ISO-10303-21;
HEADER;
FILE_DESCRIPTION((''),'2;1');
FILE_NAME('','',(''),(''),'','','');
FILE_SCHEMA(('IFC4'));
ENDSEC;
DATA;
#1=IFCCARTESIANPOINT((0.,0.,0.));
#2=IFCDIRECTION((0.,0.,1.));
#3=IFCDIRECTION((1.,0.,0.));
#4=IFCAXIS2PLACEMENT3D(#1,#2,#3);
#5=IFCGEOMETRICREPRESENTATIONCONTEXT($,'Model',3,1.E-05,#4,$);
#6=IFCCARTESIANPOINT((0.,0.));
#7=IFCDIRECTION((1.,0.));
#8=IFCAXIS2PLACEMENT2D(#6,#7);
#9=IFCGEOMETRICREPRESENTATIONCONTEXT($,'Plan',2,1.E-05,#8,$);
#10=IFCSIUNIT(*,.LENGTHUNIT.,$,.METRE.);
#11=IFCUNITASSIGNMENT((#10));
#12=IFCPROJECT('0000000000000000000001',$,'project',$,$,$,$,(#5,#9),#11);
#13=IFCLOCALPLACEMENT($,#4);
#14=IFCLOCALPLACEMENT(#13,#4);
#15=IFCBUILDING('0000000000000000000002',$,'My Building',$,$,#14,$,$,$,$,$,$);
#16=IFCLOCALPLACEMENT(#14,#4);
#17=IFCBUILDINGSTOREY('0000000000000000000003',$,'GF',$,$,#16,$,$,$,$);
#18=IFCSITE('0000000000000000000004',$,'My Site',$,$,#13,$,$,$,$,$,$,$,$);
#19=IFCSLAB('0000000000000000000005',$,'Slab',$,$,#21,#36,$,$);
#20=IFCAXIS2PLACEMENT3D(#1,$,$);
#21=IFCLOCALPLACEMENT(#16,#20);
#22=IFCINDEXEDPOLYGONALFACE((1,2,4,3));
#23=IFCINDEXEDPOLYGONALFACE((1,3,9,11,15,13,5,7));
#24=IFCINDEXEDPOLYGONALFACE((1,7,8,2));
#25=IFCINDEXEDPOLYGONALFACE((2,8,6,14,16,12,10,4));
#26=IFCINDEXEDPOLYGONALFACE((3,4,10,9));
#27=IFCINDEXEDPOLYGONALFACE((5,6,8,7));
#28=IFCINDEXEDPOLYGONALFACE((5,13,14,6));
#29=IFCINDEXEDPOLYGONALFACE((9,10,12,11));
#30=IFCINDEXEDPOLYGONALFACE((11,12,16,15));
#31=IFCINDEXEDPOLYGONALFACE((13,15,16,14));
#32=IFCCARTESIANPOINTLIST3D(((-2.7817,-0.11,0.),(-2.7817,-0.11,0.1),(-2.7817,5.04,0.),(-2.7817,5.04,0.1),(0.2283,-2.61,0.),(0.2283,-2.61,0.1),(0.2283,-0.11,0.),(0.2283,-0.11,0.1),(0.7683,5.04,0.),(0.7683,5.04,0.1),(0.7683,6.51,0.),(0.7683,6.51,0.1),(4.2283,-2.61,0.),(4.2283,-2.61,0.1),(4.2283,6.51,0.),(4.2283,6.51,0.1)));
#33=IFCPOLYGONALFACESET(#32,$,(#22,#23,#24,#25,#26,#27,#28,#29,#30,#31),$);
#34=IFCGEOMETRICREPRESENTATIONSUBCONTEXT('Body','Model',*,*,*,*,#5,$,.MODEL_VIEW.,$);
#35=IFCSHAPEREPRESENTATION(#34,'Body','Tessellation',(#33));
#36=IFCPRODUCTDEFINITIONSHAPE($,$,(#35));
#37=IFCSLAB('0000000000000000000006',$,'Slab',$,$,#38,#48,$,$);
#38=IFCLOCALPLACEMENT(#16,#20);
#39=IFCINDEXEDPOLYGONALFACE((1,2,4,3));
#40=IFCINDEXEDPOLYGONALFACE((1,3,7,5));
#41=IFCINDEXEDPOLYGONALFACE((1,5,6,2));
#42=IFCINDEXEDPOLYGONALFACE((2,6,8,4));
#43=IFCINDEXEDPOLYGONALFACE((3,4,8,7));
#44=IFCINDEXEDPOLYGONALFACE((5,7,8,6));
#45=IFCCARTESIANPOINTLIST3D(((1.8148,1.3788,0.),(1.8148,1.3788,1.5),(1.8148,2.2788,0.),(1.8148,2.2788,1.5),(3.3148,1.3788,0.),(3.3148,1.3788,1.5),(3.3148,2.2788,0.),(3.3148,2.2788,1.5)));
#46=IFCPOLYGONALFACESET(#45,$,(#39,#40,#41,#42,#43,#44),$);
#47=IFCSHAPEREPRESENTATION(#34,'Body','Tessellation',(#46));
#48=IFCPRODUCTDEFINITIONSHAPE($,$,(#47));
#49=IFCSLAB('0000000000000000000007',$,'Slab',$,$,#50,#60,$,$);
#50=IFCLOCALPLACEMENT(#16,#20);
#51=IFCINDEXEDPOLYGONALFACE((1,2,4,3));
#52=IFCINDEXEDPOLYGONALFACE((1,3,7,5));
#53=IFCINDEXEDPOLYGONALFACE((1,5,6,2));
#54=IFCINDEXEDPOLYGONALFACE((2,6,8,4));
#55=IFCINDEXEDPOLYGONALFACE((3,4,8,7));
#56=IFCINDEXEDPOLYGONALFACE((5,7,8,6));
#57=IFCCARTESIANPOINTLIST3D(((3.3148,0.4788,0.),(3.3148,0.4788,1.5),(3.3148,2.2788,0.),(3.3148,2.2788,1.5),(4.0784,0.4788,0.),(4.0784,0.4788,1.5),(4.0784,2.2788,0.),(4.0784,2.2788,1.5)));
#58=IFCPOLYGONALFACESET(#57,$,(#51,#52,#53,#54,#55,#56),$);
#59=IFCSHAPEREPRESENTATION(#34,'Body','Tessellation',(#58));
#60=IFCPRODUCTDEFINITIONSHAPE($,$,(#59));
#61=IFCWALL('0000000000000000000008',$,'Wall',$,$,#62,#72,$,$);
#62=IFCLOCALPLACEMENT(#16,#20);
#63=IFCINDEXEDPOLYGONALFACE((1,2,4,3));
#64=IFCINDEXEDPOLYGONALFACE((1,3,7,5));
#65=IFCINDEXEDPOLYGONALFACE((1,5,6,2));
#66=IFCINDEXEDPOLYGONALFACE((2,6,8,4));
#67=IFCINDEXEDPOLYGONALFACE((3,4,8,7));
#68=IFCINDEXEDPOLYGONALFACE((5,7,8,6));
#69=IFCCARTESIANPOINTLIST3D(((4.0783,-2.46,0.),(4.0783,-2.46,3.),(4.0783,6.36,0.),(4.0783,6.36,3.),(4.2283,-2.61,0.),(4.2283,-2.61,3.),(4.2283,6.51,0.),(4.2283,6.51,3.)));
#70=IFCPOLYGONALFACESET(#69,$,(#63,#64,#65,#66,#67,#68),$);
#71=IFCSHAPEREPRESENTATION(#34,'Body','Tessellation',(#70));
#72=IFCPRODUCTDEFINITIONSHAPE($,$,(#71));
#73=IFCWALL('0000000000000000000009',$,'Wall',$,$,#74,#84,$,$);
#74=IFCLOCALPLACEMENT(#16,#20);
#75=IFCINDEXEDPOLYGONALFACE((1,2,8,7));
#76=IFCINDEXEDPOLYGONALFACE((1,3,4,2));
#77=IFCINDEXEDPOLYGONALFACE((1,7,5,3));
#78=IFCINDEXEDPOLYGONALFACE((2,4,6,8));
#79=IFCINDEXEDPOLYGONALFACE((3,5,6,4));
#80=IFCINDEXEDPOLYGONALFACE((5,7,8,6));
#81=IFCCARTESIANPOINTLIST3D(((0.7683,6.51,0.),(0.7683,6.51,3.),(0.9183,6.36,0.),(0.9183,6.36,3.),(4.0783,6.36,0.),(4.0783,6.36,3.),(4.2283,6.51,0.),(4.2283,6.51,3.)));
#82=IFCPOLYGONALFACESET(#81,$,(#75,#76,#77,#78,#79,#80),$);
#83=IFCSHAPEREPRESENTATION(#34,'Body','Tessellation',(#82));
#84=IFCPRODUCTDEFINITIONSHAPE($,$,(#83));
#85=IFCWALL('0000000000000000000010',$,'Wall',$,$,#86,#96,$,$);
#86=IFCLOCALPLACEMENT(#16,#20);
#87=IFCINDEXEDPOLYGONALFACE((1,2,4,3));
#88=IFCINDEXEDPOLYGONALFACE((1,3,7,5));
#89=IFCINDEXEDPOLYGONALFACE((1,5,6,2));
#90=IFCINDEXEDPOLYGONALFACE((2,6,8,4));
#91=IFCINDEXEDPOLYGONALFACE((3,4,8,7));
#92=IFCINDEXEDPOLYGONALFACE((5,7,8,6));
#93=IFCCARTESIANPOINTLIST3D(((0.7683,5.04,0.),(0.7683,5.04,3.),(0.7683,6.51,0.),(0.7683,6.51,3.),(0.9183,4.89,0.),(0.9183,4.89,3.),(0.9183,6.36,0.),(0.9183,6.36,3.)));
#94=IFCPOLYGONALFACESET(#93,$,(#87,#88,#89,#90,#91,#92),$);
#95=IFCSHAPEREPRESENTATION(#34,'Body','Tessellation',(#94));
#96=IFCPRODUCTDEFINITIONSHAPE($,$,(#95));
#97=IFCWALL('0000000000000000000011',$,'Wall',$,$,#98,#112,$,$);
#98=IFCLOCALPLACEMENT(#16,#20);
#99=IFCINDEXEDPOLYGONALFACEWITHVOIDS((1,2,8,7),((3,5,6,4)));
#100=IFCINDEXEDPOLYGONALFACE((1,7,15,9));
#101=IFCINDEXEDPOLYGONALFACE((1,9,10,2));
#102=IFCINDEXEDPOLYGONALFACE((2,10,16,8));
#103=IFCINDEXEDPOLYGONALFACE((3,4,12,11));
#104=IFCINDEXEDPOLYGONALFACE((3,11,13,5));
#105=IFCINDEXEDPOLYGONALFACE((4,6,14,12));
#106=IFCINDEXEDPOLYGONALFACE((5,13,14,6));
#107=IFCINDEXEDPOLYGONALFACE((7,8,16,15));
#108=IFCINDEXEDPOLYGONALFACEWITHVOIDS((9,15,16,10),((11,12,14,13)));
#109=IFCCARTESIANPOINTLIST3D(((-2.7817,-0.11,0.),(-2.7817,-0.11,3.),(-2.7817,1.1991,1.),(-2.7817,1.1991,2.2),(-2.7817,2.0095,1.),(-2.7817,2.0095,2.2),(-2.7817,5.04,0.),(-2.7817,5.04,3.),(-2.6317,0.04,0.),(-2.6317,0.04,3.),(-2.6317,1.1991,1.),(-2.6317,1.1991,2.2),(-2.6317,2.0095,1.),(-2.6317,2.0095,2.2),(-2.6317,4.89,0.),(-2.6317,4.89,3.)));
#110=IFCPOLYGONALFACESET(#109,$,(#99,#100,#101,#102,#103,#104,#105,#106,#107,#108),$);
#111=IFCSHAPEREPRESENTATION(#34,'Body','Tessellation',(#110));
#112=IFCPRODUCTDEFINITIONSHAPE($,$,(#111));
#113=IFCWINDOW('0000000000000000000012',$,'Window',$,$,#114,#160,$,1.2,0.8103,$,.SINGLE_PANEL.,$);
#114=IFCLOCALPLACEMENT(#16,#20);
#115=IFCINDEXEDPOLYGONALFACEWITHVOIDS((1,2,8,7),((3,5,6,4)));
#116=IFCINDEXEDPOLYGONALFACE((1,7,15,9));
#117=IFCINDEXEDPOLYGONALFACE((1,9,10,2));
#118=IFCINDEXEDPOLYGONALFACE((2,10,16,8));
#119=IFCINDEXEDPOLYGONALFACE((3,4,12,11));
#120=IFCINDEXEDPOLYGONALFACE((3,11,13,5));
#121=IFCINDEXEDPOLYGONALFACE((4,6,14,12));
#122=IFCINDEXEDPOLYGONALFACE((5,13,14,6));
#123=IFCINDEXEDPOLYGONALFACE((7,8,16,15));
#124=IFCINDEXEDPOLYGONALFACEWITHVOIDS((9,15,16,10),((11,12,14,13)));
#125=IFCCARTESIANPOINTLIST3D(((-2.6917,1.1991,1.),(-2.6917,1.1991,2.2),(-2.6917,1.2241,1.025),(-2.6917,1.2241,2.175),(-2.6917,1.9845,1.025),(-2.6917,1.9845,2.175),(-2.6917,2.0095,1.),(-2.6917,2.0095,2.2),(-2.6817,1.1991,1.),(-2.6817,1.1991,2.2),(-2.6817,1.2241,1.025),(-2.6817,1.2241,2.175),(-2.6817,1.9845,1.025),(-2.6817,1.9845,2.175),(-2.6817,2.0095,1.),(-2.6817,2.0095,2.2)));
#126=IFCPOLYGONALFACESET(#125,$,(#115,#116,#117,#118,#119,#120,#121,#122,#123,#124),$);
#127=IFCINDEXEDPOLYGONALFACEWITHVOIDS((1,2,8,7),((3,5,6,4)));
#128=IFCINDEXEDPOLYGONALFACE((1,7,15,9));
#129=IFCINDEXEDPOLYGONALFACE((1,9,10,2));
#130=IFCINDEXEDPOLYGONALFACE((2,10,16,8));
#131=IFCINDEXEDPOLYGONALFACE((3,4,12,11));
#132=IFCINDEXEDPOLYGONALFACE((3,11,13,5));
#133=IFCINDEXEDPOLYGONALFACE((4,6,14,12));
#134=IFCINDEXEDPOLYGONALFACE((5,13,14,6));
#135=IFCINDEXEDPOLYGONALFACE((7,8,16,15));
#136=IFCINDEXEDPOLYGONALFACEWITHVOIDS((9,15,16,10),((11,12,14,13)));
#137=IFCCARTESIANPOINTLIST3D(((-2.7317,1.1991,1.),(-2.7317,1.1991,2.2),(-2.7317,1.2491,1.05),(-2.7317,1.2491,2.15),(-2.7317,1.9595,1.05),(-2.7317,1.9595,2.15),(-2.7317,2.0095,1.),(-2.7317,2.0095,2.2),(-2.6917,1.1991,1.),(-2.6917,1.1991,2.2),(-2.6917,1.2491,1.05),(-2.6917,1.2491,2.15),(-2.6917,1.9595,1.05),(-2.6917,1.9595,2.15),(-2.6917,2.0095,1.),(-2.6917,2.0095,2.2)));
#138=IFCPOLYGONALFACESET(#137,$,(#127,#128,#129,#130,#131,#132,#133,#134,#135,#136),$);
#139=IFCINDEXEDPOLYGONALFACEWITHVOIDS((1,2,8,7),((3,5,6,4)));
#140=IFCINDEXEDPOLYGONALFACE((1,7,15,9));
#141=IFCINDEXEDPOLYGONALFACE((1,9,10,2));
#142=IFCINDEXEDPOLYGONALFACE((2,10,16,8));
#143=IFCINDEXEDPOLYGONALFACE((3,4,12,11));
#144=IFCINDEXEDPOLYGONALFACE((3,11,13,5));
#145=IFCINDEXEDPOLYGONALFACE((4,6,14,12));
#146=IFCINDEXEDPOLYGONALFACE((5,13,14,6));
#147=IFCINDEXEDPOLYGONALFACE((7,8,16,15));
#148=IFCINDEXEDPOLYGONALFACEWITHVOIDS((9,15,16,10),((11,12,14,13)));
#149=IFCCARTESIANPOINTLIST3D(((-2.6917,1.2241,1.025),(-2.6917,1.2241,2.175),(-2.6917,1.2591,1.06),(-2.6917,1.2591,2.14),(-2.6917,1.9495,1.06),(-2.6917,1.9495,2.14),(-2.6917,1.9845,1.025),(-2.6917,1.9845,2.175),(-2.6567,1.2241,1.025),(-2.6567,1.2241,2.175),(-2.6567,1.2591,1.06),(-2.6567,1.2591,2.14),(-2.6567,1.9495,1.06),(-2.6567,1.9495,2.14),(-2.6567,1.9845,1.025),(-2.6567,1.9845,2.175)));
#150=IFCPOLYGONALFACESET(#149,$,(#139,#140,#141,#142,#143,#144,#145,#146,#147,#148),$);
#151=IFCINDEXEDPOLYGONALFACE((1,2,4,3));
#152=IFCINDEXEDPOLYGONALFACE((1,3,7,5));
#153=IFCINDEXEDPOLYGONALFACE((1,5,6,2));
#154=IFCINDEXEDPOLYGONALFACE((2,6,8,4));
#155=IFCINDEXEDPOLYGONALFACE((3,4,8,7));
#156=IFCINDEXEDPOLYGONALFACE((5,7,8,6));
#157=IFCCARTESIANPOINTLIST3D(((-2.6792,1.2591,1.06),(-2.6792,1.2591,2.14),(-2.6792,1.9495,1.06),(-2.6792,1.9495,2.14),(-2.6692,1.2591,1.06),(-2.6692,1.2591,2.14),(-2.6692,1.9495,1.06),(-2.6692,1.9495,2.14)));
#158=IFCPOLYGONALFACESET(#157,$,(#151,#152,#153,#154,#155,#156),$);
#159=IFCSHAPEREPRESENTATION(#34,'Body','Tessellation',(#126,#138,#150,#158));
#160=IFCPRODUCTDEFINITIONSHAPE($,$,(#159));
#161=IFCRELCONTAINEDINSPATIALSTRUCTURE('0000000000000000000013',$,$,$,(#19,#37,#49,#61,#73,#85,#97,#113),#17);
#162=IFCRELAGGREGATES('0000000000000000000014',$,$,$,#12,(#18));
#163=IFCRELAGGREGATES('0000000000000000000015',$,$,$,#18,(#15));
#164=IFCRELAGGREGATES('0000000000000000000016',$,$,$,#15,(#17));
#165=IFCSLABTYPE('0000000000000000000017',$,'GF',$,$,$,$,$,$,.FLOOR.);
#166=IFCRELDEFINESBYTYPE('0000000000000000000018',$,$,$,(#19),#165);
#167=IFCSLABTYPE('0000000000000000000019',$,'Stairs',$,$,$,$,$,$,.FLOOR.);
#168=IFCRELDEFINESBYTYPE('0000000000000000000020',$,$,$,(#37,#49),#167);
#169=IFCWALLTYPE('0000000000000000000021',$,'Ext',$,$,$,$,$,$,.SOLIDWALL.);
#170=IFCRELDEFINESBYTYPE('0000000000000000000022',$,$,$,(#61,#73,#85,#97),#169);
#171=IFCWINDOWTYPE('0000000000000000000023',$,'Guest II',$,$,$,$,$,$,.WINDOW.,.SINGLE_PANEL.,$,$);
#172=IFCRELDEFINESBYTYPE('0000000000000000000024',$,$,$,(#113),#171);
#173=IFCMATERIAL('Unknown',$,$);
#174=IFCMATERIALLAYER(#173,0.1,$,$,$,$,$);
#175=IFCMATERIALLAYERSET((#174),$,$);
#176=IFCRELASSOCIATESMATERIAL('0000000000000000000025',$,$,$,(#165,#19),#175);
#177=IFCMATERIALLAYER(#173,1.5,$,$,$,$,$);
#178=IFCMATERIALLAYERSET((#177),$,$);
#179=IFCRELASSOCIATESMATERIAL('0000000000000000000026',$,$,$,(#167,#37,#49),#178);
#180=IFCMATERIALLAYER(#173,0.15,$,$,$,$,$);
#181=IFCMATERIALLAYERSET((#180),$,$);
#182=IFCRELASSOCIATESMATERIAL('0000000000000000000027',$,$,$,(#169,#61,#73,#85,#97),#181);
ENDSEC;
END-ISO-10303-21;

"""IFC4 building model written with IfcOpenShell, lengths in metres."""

from ifc_helpers import new_model, entity, si_unit, frame, origin_with_axes, origin_2d_with_axis, place, context, subcontext, project, spatial, line, indexed_curve, outline, extrude, shape, source, transform, mapped, material, layer, layer_set, layer_usage, type_object, type_shapes, element, fill, save


model = new_model("IFC4")

# Units and contexts
model_context = context("Model", 3, precision=1e-05, world=origin_with_axes())
plan_context = context("Plan", 2, precision=1e-05, world=origin_2d_with_axis())
body_context_1 = subcontext(model_context, "Body", "Model", "MODEL_VIEW")
body_context_2 = subcontext(plan_context, "Body", "Plan", "PLAN_VIEW")
ifc_project = project(units=[si_unit("LENGTHUNIT", "METRE")], contexts=[model_context, plan_context])

# Site, building, storey
site_placement = place(None, origin_with_axes())
site = spatial("IfcSite", under=ifc_project, at=site_placement, Name="My Site")
building_placement = place(site_placement, origin_with_axes())
building = spatial("IfcBuilding", under=site, at=building_placement, Name="My Building")
storey_placement = place(building_placement, origin_with_axes())
storey = spatial("IfcBuildingStorey", under=building, at=storey_placement, Name="GF")

# Slabs
ifc_material = material(Name="Unknown")
ifc_layer_1 = layer(ifc_material, 0.1)
ifc_layer_set_1 = layer_set([ifc_layer_1])
ifc_layer_usage_1 = layer_usage(ifc_layer_set_1, "AXIS3", "POSITIVE", -0.1)
slab_type_1 = type_object("IfcSlabType", Name="GF", PredefinedType="FLOOR", material=ifc_layer_set_1)
slab_1_placement = place(storey_placement, frame((-2.7817, 5.04, 0.1), z_axis=(0.0, 0.0, 1.0), x_axis=(1.0, 0.0, 0.0)))
element("IfcSlab", 1, at=slab_1_placement, inside=storey, type_object=slab_type_1, material=ifc_layer_usage_1, Name="Slab", context=body_context_1, shape_type="SweptSolid", body=[
    extrude(outline(indexed_curve([(0.0, 0.0), (3.55, 0.0), (3.55, 1.47), (7.01, 1.47), (7.01, -7.65), (3.01, -7.65), (3.01, -5.15), (0.0, -5.15), (0.0, 0.0)])), frame((0.0, 0.0, -0.1), z_axis=(0.0, 0.0, 1.0), x_axis=(1.0, 0.0, 0.0)), (0.0, 0.0, 1.0), 0.1),
])
ifc_layer_2 = layer(ifc_material, 1.5)
ifc_layer_set_2 = layer_set([ifc_layer_2])
ifc_layer_usage_2 = layer_usage(ifc_layer_set_2, "AXIS3", "POSITIVE", -1.5)
slab_type_2 = type_object("IfcSlabType", Name="Stairs", PredefinedType="FLOOR", material=ifc_layer_set_2)
slab_2_placement = place(storey_placement, frame((3.3148, 2.2788, 1.5), z_axis=(0.0, 0.0, 1.0), x_axis=(1.0, 0.0, 0.0)))
element("IfcSlab", 2, at=slab_2_placement, inside=storey, type_object=slab_type_2, material=ifc_layer_usage_2, Name="Slab", context=body_context_1, shape_type="SweptSolid", body=[
    extrude(outline(indexed_curve([(0.0, 0.0), (0.0, -0.9), (-1.5, -0.9), (-1.5, 0.0), (0.0, 0.0)])), frame((0.0, 0.0, -1.5), z_axis=(0.0, 0.0, 1.0), x_axis=(1.0, 0.0, 0.0)), (0.0, 0.0, 1.0), 1.5),
])
ifc_layer_usage_3 = layer_usage(ifc_layer_set_2, "AXIS3", "POSITIVE", -1.5)
slab_3_placement = place(storey_placement, frame((3.3148, 0.4788, 1.5), z_axis=(0.0, 0.0, 1.0), x_axis=(1.0, 0.0, 0.0)))
element("IfcSlab", 3, at=slab_3_placement, inside=storey, type_object=slab_type_2, material=ifc_layer_usage_3, Name="Slab", context=body_context_1, shape_type="SweptSolid", body=[
    extrude(outline(indexed_curve([(0.0, 0.0), (0.7636, 0.0), (0.7636, 1.8), (0.0, 1.8), (0.0, 0.0)])), frame((0.0, 0.0, -1.5), z_axis=(0.0, 0.0, 1.0), x_axis=(1.0, 0.0, 0.0)), (0.0, 0.0, 1.0), 1.5),
])

# Shared definitions
ifc_layer_3 = layer(ifc_material, 0.15)
ifc_layer_set_3 = layer_set([ifc_layer_3])
wall_type_1 = type_object("IfcWallType", Name="Ext", PredefinedType="SOLIDWALL", material=ifc_layer_set_3)

# Walls
ifc_layer_usage_4 = layer_usage(ifc_layer_set_3, "AXIS2", "POSITIVE", 0.0)
wall_1_placement = place(storey_placement, frame((4.2283, -2.61, 0.0), z_axis=(0.0, 0.0, 1.0), x_axis=(0.0, 1.0, 0.0)))
element("IfcWall", 4, at=wall_1_placement, inside=storey, type_object=wall_type_1, material=ifc_layer_usage_4, Name="Wall", context=body_context_1, shape_type="SweptSolid", body=[
    extrude(outline(indexed_curve([(0.0, 0.0), (0.15, 0.15), (8.97, 0.15), (9.12, 0.0)], segments=[line(1, 2, 3, 4, 1)])), origin_with_axes(), (0.0, 0.0, 1.0), 3.0),
])
ifc_layer_usage_5 = layer_usage(ifc_layer_set_3, "AXIS2", "POSITIVE", 0.0)
wall_2_placement = place(storey_placement, frame((4.2283, 6.51, 0.0), z_axis=(0.0, 0.0, 1.0), x_axis=(-1.0, 0.0, 0.0)))
element("IfcWall", 5, at=wall_2_placement, inside=storey, type_object=wall_type_1, material=ifc_layer_usage_5, Name="Wall", context=body_context_1, shape_type="SweptSolid", body=[
    extrude(outline(indexed_curve([(0.0, 0.0), (0.15, 0.15), (3.31, 0.15), (3.46, 0.0)], segments=[line(1, 2, 3, 4, 1)])), origin_with_axes(), (0.0, 0.0, 1.0), 3.0),
])
ifc_layer_usage_6 = layer_usage(ifc_layer_set_3, "AXIS2", "POSITIVE", 0.0)
wall_3_placement = place(storey_placement, frame((0.7683, 6.51, 0.0), z_axis=(0.0, 0.0, 1.0), x_axis=(0.0, -1.0, 0.0)))
element("IfcWall", 6, at=wall_3_placement, inside=storey, type_object=wall_type_1, material=ifc_layer_usage_6, Name="Wall", context=body_context_1, shape_type="SweptSolid", body=[
    extrude(outline(indexed_curve([(0.0, 0.0), (0.15, 0.15), (1.62, 0.15), (1.47, 0.0)], segments=[line(1, 2, 3, 4, 1)])), origin_with_axes(), (0.0, 0.0, 1.0), 3.0),
])

# Wall, opening, window
ifc_layer_usage_7 = layer_usage(ifc_layer_set_3, "AXIS2", "POSITIVE", 0.0)
wall_4_placement = place(storey_placement, frame((-2.7817, 5.04, 0.0), z_axis=(0.0, 0.0, 1.0), x_axis=(0.0, -1.0, 0.0)))
wall_4 = element("IfcWall", 7, at=wall_4_placement, inside=storey, type_object=wall_type_1, material=ifc_layer_usage_7, Name="Wall", context=body_context_1, shape_type="SweptSolid", body=[
    extrude(outline(indexed_curve([(0.0, 0.0), (0.15, 0.15), (5.0, 0.15), (5.15, 0.0)], segments=[line(1, 2, 3, 4, 1)])), origin_with_axes(), (0.0, 0.0, 1.0), 3.0),
])
shared_shape_1 = source(origin_with_axes(), body_context_1, "Body", "SweptSolid", [
    extrude(outline(indexed_curve([(0.0, 0.0), (0.8103, 0.0), (0.8103, 1.2), (0.0, 1.2)], segments=[line(1, 2, 3, 4, 1)])), frame((0.0, -0.6, 0.0), z_axis=(0.0, -1.0, 0.0), x_axis=(1.0, 0.0, 0.0)), (0.0, 0.0, -1.0), 1.2),
])
opening_1_placement = place(wall_4_placement, frame((3.0305, 0.0, 1.0), z_axis=(0.0, 0.0, 1.0), x_axis=(1.0, 0.0, 0.0)))
opening_1 = element("IfcOpeningElement", 8, at=opening_1_placement, cuts=wall_4, PredefinedType="OPENING", context=body_context_1, shape_type="MappedRepresentation", body=[
    mapped(shared_shape_1, transform((0.0, 0.0, 0.0), x_axis=(1.0, 0.0, 0.0), y_axis=(0.0, 1.0, 0.0), z_axis=(0.0, 0.0, 1.0), scale=1.0)),
])
window_type_1 = type_object("IfcWindowType", Name="Guest II", PartitioningType="SINGLE_PANEL", PredefinedType="WINDOW")
shared_shape_2 = source(origin_with_axes(), body_context_1, "Body", "SweptSolid", [
    extrude(outline(indexed_curve([(0.0, 0.0), (0.8103, 0.0), (0.8103, 1.2), (0.0, 1.2)], segments=[line(1, 2, 3, 4, 1)]), holes=[indexed_curve([(0.025, 0.025), (0.7853, 0.025), (0.7853, 1.175), (0.025, 1.175)], segments=[line(1, 2, 3, 4, 1)])]), frame((0.0, 0.09, 0.0), z_axis=(0.0, -1.0, 0.0), x_axis=(1.0, 0.0, 0.0)), (0.0, 0.0, -1.0), 0.01),
    extrude(outline(indexed_curve([(0.0, 0.0), (0.8103, 0.0), (0.8103, 1.2), (0.0, 1.2)], segments=[line(1, 2, 3, 4, 1)]), holes=[indexed_curve([(0.05, 0.05), (0.7603, 0.05), (0.7603, 1.15), (0.05, 1.15)], segments=[line(1, 2, 3, 4, 1)])]), frame((0.0, 0.05, 0.0), z_axis=(0.0, -1.0, 0.0), x_axis=(1.0, 0.0, 0.0)), (0.0, 0.0, -1.0), 0.04),
    extrude(outline(indexed_curve([(0.0, 0.0), (0.7603, 0.0), (0.7603, 1.15), (0.0, 1.15)], segments=[line(1, 2, 3, 4, 1)]), holes=[indexed_curve([(0.035, 0.035), (0.7253, 0.035), (0.7253, 1.115), (0.035, 1.115)], segments=[line(1, 2, 3, 4, 1)])]), frame((0.025, 0.09, 0.025), z_axis=(0.0, -1.0, 0.0), x_axis=(1.0, 0.0, 0.0)), (0.0, 0.0, -1.0), 0.035),
    extrude(outline(indexed_curve([(0.035, 0.035), (0.7253, 0.035), (0.7253, 1.115), (0.035, 1.115)], segments=[line(1, 2, 3, 4, 1)])), frame((0.025, 0.1025, 0.025), z_axis=(0.0, -1.0, 0.0), x_axis=(1.0, 0.0, 0.0)), (0.0, 0.0, -1.0), 0.01),
])
shared_shape_3 = source(origin_with_axes(), body_context_2, "Body", "Curve2D", [
    entity("IfcIndexedPolyCurve", entity("IfcCartesianPointList2D", [[0.05, 0.05], [0.7603, 0.05]])),
    entity("IfcIndexedPolyCurve", entity("IfcCartesianPointList2D", [[0.0, 0.1], [0.025, 0.1], [0.025, 0.09], [0.05, 0.09], [0.05, 0.05], [0.0, 0.05]]), [entity("IfcLineIndex", [1, 2, 3, 4, 5, 6, 1])]),
    entity("IfcIndexedPolyCurve", entity("IfcCartesianPointList2D", [[0.8103, 0.1], [0.7853, 0.1], [0.7853, 0.09], [0.7603, 0.09], [0.7603, 0.05], [0.8103, 0.05]]), [entity("IfcLineIndex", [1, 2, 3, 4, 5, 6, 1])]),
    entity("IfcIndexedPolyCurve", entity("IfcCartesianPointList2D", [[0.025, 0.09], [0.06, 0.09], [0.06, 0.125], [0.025, 0.125]]), [entity("IfcLineIndex", [1, 2, 3, 4, 1])]),
    entity("IfcIndexedPolyCurve", entity("IfcCartesianPointList2D", [[0.7853, 0.09], [0.7503, 0.09], [0.7503, 0.125], [0.7853, 0.125]]), [entity("IfcLineIndex", [1, 2, 3, 4, 1])]),
    entity("IfcIndexedPolyCurve", entity("IfcCartesianPointList2D", [[0.06, 0.09], [0.7503, 0.09]])),
    entity("IfcIndexedPolyCurve", entity("IfcCartesianPointList2D", [[0.06, 0.125], [0.7503, 0.125]])),
    entity("IfcIndexedPolyCurve", entity("IfcCartesianPointList2D", [[0.06, 0.1075], [0.7503, 0.1075]])),
])
type_shapes(window_type_1, [shared_shape_2, shared_shape_3])
window_1_placement = place(opening_1_placement, frame((0.0, 0.0, 0.0), z_axis=(0.0, 0.0, 1.0), x_axis=(1.0, 0.0, 0.0)))
window_1 = element("IfcWindow", 9, at=window_1_placement, inside=storey, type_object=window_type_1, Name="Window", OverallHeight=1.2, OverallWidth=0.8103, PartitioningType="SINGLE_PANEL", shapes=[
    shape(body_context_1, "Body", "MappedRepresentation", [mapped(shared_shape_2, transform((0.0, 0.0, 0.0), x_axis=(1.0, 0.0, 0.0), y_axis=(0.0, 1.0, 0.0), z_axis=(0.0, 0.0, 1.0), scale=1.0))]),
    shape(body_context_2, "Body", "MappedRepresentation", [mapped(shared_shape_3, transform((0.0, 0.0, 0.0), x_axis=(1.0, 0.0, 0.0), y_axis=(0.0, 1.0, 0.0), z_axis=(0.0, 0.0, 1.0), scale=1.0))]),
])
fill(opening_1, window_1)

save(model, "model.ifc")
